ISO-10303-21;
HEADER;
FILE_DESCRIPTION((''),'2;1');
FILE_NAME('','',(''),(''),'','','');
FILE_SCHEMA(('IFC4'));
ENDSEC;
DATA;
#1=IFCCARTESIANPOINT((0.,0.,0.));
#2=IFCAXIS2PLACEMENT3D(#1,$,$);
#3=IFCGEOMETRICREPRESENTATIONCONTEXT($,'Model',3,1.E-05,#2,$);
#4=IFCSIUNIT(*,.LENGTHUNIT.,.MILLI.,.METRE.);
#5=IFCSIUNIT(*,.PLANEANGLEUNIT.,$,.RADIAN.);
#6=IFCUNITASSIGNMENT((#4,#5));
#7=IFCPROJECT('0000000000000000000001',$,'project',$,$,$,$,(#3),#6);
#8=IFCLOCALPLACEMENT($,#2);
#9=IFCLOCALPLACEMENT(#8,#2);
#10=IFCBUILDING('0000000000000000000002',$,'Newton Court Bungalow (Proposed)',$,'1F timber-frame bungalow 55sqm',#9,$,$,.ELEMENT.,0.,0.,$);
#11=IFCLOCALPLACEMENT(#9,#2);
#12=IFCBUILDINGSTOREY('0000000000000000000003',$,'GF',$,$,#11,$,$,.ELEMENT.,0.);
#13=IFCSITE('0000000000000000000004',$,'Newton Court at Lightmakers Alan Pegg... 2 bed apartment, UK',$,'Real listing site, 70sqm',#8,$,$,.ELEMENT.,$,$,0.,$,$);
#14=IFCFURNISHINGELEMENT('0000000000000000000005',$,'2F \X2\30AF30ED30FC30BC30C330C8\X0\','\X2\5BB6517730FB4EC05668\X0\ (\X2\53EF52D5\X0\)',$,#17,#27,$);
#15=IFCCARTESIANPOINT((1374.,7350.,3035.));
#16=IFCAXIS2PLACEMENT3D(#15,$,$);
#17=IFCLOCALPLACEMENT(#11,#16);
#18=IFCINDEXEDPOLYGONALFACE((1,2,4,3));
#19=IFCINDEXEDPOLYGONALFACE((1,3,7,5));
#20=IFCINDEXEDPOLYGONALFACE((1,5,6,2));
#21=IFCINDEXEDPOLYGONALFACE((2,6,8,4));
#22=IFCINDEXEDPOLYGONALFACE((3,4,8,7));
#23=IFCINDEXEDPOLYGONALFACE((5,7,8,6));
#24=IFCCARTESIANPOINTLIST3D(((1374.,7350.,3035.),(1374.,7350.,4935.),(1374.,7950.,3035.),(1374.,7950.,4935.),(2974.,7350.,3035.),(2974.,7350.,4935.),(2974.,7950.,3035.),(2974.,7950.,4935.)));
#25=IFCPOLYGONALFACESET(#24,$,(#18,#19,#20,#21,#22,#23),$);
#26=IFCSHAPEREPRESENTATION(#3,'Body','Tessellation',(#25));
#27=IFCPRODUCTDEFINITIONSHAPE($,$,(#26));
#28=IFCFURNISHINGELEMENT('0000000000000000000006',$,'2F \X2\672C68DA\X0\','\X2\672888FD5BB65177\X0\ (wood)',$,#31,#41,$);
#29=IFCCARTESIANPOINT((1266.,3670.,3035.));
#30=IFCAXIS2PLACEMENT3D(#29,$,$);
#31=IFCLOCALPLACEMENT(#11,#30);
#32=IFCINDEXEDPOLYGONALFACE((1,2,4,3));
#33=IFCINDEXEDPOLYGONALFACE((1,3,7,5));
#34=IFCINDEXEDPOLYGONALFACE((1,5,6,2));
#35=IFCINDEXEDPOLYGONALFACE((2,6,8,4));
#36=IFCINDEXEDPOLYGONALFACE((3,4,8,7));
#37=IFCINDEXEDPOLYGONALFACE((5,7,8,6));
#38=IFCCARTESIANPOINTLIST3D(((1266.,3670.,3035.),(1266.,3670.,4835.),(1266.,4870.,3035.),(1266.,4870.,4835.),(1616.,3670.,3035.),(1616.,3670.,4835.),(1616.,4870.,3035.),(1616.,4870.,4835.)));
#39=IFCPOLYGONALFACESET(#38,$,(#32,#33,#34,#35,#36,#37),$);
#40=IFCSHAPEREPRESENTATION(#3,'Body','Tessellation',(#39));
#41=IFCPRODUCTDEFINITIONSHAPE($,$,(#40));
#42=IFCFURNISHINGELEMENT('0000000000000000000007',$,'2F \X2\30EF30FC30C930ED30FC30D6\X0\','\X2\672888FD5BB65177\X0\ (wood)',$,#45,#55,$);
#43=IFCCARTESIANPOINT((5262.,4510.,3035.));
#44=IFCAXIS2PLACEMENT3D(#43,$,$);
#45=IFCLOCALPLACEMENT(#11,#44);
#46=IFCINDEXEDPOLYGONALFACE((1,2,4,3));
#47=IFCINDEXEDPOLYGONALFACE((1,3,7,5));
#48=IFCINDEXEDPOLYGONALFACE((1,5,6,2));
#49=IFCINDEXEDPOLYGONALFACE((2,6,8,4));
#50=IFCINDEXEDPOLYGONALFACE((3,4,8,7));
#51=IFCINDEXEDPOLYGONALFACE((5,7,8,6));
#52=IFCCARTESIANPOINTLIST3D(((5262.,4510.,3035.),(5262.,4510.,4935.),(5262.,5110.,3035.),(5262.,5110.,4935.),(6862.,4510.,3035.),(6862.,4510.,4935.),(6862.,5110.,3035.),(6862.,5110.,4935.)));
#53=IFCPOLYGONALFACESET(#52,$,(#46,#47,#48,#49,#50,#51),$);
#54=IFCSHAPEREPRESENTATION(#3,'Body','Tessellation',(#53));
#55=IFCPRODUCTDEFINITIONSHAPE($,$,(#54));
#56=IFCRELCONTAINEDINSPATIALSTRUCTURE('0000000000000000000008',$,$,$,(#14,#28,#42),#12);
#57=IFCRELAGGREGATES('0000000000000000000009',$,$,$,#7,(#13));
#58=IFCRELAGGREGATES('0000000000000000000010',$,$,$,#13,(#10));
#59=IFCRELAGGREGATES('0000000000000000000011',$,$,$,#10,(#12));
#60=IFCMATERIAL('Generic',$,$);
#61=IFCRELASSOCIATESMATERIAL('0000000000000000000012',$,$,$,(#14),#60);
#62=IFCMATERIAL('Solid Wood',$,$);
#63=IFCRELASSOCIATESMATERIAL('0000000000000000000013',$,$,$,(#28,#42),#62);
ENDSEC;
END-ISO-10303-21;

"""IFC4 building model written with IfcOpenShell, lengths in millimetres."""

from ifc_helpers import new_model, si_unit, frame, frame_2d, origin, place, context, project, spatial, rectangle, extrude, material, element, save


model = new_model("IFC4")

# Units and contexts
model_context = context("Model", 3, precision=1e-05, world=origin())
ifc_project = project(units=[si_unit("LENGTHUNIT", "METRE", prefix="MILLI"), si_unit("PLANEANGLEUNIT", "RADIAN")], contexts=[model_context])

# Site, building, storey
site_placement = place(None, origin())
site = spatial("IfcSite", under=ifc_project, at=site_placement, Name="Newton Court at Lightmakers Alan Pegg... 2 bed apartment, UK", ObjectType="Real listing site, 70sqm", CompositionType="ELEMENT", RefElevation=0.0)
building_placement = place(site_placement, origin())
building = spatial("IfcBuilding", under=site, at=building_placement, Name="Newton Court Bungalow (Proposed)", ObjectType="1F timber-frame bungalow 55sqm", CompositionType="ELEMENT", ElevationOfRefHeight=0.0, ElevationOfTerrain=0.0)
storey_placement = place(building_placement, origin())
storey = spatial("IfcBuildingStorey", under=building, at=storey_placement, Name="GF", CompositionType="ELEMENT", Elevation=0.0)

# Shared definitions
ifc_material_1 = material(Name="Solid Wood")

# Shared definitions
ifc_material_2 = material(Name="Generic")

# Furnishing elements
furnishing_1_placement = place(storey_placement, frame((1374.0, 7350.0, 3035.0)))
element("IfcFurnishingElement", 1, at=furnishing_1_placement, inside=storey, material=ifc_material_2, Name="2F クローゼット", Description="家具・什器 (可動)", context=model_context, shape_type="SweptSolid", body=[
    extrude(rectangle(XDim=1600.0, YDim=600.0, at=frame_2d((800.0, 300.0))), frame((1374.0, 7350.0, 3035.0)), (0.0, 0.0, 1.0), 1900.0),
])
furnishing_2_placement = place(storey_placement, frame((1266.0, 3670.0, 3035.0)))
element("IfcFurnishingElement", 2, at=furnishing_2_placement, inside=storey, material=ifc_material_1, Name="2F 本棚", Description="木製家具 (wood)", context=model_context, shape_type="SweptSolid", body=[
    extrude(rectangle(XDim=350.0, YDim=1200.0, at=frame_2d((175.0, 600.0))), frame((1266.0, 3670.0, 3035.0)), (0.0, 0.0, 1.0), 1800.0),
])
furnishing_3_placement = place(storey_placement, frame((5262.0, 4510.0, 3035.0)))
element("IfcFurnishingElement", 3, at=furnishing_3_placement, inside=storey, material=ifc_material_1, Name="2F ワードローブ", Description="木製家具 (wood)", context=model_context, shape_type="SweptSolid", body=[
    extrude(rectangle(XDim=1600.0, YDim=600.0, at=frame_2d((800.0, 300.0))), frame((5262.0, 4510.0, 3035.0)), (0.0, 0.0, 1.0), 1900.0),
])

save(model, "model.ifc")
